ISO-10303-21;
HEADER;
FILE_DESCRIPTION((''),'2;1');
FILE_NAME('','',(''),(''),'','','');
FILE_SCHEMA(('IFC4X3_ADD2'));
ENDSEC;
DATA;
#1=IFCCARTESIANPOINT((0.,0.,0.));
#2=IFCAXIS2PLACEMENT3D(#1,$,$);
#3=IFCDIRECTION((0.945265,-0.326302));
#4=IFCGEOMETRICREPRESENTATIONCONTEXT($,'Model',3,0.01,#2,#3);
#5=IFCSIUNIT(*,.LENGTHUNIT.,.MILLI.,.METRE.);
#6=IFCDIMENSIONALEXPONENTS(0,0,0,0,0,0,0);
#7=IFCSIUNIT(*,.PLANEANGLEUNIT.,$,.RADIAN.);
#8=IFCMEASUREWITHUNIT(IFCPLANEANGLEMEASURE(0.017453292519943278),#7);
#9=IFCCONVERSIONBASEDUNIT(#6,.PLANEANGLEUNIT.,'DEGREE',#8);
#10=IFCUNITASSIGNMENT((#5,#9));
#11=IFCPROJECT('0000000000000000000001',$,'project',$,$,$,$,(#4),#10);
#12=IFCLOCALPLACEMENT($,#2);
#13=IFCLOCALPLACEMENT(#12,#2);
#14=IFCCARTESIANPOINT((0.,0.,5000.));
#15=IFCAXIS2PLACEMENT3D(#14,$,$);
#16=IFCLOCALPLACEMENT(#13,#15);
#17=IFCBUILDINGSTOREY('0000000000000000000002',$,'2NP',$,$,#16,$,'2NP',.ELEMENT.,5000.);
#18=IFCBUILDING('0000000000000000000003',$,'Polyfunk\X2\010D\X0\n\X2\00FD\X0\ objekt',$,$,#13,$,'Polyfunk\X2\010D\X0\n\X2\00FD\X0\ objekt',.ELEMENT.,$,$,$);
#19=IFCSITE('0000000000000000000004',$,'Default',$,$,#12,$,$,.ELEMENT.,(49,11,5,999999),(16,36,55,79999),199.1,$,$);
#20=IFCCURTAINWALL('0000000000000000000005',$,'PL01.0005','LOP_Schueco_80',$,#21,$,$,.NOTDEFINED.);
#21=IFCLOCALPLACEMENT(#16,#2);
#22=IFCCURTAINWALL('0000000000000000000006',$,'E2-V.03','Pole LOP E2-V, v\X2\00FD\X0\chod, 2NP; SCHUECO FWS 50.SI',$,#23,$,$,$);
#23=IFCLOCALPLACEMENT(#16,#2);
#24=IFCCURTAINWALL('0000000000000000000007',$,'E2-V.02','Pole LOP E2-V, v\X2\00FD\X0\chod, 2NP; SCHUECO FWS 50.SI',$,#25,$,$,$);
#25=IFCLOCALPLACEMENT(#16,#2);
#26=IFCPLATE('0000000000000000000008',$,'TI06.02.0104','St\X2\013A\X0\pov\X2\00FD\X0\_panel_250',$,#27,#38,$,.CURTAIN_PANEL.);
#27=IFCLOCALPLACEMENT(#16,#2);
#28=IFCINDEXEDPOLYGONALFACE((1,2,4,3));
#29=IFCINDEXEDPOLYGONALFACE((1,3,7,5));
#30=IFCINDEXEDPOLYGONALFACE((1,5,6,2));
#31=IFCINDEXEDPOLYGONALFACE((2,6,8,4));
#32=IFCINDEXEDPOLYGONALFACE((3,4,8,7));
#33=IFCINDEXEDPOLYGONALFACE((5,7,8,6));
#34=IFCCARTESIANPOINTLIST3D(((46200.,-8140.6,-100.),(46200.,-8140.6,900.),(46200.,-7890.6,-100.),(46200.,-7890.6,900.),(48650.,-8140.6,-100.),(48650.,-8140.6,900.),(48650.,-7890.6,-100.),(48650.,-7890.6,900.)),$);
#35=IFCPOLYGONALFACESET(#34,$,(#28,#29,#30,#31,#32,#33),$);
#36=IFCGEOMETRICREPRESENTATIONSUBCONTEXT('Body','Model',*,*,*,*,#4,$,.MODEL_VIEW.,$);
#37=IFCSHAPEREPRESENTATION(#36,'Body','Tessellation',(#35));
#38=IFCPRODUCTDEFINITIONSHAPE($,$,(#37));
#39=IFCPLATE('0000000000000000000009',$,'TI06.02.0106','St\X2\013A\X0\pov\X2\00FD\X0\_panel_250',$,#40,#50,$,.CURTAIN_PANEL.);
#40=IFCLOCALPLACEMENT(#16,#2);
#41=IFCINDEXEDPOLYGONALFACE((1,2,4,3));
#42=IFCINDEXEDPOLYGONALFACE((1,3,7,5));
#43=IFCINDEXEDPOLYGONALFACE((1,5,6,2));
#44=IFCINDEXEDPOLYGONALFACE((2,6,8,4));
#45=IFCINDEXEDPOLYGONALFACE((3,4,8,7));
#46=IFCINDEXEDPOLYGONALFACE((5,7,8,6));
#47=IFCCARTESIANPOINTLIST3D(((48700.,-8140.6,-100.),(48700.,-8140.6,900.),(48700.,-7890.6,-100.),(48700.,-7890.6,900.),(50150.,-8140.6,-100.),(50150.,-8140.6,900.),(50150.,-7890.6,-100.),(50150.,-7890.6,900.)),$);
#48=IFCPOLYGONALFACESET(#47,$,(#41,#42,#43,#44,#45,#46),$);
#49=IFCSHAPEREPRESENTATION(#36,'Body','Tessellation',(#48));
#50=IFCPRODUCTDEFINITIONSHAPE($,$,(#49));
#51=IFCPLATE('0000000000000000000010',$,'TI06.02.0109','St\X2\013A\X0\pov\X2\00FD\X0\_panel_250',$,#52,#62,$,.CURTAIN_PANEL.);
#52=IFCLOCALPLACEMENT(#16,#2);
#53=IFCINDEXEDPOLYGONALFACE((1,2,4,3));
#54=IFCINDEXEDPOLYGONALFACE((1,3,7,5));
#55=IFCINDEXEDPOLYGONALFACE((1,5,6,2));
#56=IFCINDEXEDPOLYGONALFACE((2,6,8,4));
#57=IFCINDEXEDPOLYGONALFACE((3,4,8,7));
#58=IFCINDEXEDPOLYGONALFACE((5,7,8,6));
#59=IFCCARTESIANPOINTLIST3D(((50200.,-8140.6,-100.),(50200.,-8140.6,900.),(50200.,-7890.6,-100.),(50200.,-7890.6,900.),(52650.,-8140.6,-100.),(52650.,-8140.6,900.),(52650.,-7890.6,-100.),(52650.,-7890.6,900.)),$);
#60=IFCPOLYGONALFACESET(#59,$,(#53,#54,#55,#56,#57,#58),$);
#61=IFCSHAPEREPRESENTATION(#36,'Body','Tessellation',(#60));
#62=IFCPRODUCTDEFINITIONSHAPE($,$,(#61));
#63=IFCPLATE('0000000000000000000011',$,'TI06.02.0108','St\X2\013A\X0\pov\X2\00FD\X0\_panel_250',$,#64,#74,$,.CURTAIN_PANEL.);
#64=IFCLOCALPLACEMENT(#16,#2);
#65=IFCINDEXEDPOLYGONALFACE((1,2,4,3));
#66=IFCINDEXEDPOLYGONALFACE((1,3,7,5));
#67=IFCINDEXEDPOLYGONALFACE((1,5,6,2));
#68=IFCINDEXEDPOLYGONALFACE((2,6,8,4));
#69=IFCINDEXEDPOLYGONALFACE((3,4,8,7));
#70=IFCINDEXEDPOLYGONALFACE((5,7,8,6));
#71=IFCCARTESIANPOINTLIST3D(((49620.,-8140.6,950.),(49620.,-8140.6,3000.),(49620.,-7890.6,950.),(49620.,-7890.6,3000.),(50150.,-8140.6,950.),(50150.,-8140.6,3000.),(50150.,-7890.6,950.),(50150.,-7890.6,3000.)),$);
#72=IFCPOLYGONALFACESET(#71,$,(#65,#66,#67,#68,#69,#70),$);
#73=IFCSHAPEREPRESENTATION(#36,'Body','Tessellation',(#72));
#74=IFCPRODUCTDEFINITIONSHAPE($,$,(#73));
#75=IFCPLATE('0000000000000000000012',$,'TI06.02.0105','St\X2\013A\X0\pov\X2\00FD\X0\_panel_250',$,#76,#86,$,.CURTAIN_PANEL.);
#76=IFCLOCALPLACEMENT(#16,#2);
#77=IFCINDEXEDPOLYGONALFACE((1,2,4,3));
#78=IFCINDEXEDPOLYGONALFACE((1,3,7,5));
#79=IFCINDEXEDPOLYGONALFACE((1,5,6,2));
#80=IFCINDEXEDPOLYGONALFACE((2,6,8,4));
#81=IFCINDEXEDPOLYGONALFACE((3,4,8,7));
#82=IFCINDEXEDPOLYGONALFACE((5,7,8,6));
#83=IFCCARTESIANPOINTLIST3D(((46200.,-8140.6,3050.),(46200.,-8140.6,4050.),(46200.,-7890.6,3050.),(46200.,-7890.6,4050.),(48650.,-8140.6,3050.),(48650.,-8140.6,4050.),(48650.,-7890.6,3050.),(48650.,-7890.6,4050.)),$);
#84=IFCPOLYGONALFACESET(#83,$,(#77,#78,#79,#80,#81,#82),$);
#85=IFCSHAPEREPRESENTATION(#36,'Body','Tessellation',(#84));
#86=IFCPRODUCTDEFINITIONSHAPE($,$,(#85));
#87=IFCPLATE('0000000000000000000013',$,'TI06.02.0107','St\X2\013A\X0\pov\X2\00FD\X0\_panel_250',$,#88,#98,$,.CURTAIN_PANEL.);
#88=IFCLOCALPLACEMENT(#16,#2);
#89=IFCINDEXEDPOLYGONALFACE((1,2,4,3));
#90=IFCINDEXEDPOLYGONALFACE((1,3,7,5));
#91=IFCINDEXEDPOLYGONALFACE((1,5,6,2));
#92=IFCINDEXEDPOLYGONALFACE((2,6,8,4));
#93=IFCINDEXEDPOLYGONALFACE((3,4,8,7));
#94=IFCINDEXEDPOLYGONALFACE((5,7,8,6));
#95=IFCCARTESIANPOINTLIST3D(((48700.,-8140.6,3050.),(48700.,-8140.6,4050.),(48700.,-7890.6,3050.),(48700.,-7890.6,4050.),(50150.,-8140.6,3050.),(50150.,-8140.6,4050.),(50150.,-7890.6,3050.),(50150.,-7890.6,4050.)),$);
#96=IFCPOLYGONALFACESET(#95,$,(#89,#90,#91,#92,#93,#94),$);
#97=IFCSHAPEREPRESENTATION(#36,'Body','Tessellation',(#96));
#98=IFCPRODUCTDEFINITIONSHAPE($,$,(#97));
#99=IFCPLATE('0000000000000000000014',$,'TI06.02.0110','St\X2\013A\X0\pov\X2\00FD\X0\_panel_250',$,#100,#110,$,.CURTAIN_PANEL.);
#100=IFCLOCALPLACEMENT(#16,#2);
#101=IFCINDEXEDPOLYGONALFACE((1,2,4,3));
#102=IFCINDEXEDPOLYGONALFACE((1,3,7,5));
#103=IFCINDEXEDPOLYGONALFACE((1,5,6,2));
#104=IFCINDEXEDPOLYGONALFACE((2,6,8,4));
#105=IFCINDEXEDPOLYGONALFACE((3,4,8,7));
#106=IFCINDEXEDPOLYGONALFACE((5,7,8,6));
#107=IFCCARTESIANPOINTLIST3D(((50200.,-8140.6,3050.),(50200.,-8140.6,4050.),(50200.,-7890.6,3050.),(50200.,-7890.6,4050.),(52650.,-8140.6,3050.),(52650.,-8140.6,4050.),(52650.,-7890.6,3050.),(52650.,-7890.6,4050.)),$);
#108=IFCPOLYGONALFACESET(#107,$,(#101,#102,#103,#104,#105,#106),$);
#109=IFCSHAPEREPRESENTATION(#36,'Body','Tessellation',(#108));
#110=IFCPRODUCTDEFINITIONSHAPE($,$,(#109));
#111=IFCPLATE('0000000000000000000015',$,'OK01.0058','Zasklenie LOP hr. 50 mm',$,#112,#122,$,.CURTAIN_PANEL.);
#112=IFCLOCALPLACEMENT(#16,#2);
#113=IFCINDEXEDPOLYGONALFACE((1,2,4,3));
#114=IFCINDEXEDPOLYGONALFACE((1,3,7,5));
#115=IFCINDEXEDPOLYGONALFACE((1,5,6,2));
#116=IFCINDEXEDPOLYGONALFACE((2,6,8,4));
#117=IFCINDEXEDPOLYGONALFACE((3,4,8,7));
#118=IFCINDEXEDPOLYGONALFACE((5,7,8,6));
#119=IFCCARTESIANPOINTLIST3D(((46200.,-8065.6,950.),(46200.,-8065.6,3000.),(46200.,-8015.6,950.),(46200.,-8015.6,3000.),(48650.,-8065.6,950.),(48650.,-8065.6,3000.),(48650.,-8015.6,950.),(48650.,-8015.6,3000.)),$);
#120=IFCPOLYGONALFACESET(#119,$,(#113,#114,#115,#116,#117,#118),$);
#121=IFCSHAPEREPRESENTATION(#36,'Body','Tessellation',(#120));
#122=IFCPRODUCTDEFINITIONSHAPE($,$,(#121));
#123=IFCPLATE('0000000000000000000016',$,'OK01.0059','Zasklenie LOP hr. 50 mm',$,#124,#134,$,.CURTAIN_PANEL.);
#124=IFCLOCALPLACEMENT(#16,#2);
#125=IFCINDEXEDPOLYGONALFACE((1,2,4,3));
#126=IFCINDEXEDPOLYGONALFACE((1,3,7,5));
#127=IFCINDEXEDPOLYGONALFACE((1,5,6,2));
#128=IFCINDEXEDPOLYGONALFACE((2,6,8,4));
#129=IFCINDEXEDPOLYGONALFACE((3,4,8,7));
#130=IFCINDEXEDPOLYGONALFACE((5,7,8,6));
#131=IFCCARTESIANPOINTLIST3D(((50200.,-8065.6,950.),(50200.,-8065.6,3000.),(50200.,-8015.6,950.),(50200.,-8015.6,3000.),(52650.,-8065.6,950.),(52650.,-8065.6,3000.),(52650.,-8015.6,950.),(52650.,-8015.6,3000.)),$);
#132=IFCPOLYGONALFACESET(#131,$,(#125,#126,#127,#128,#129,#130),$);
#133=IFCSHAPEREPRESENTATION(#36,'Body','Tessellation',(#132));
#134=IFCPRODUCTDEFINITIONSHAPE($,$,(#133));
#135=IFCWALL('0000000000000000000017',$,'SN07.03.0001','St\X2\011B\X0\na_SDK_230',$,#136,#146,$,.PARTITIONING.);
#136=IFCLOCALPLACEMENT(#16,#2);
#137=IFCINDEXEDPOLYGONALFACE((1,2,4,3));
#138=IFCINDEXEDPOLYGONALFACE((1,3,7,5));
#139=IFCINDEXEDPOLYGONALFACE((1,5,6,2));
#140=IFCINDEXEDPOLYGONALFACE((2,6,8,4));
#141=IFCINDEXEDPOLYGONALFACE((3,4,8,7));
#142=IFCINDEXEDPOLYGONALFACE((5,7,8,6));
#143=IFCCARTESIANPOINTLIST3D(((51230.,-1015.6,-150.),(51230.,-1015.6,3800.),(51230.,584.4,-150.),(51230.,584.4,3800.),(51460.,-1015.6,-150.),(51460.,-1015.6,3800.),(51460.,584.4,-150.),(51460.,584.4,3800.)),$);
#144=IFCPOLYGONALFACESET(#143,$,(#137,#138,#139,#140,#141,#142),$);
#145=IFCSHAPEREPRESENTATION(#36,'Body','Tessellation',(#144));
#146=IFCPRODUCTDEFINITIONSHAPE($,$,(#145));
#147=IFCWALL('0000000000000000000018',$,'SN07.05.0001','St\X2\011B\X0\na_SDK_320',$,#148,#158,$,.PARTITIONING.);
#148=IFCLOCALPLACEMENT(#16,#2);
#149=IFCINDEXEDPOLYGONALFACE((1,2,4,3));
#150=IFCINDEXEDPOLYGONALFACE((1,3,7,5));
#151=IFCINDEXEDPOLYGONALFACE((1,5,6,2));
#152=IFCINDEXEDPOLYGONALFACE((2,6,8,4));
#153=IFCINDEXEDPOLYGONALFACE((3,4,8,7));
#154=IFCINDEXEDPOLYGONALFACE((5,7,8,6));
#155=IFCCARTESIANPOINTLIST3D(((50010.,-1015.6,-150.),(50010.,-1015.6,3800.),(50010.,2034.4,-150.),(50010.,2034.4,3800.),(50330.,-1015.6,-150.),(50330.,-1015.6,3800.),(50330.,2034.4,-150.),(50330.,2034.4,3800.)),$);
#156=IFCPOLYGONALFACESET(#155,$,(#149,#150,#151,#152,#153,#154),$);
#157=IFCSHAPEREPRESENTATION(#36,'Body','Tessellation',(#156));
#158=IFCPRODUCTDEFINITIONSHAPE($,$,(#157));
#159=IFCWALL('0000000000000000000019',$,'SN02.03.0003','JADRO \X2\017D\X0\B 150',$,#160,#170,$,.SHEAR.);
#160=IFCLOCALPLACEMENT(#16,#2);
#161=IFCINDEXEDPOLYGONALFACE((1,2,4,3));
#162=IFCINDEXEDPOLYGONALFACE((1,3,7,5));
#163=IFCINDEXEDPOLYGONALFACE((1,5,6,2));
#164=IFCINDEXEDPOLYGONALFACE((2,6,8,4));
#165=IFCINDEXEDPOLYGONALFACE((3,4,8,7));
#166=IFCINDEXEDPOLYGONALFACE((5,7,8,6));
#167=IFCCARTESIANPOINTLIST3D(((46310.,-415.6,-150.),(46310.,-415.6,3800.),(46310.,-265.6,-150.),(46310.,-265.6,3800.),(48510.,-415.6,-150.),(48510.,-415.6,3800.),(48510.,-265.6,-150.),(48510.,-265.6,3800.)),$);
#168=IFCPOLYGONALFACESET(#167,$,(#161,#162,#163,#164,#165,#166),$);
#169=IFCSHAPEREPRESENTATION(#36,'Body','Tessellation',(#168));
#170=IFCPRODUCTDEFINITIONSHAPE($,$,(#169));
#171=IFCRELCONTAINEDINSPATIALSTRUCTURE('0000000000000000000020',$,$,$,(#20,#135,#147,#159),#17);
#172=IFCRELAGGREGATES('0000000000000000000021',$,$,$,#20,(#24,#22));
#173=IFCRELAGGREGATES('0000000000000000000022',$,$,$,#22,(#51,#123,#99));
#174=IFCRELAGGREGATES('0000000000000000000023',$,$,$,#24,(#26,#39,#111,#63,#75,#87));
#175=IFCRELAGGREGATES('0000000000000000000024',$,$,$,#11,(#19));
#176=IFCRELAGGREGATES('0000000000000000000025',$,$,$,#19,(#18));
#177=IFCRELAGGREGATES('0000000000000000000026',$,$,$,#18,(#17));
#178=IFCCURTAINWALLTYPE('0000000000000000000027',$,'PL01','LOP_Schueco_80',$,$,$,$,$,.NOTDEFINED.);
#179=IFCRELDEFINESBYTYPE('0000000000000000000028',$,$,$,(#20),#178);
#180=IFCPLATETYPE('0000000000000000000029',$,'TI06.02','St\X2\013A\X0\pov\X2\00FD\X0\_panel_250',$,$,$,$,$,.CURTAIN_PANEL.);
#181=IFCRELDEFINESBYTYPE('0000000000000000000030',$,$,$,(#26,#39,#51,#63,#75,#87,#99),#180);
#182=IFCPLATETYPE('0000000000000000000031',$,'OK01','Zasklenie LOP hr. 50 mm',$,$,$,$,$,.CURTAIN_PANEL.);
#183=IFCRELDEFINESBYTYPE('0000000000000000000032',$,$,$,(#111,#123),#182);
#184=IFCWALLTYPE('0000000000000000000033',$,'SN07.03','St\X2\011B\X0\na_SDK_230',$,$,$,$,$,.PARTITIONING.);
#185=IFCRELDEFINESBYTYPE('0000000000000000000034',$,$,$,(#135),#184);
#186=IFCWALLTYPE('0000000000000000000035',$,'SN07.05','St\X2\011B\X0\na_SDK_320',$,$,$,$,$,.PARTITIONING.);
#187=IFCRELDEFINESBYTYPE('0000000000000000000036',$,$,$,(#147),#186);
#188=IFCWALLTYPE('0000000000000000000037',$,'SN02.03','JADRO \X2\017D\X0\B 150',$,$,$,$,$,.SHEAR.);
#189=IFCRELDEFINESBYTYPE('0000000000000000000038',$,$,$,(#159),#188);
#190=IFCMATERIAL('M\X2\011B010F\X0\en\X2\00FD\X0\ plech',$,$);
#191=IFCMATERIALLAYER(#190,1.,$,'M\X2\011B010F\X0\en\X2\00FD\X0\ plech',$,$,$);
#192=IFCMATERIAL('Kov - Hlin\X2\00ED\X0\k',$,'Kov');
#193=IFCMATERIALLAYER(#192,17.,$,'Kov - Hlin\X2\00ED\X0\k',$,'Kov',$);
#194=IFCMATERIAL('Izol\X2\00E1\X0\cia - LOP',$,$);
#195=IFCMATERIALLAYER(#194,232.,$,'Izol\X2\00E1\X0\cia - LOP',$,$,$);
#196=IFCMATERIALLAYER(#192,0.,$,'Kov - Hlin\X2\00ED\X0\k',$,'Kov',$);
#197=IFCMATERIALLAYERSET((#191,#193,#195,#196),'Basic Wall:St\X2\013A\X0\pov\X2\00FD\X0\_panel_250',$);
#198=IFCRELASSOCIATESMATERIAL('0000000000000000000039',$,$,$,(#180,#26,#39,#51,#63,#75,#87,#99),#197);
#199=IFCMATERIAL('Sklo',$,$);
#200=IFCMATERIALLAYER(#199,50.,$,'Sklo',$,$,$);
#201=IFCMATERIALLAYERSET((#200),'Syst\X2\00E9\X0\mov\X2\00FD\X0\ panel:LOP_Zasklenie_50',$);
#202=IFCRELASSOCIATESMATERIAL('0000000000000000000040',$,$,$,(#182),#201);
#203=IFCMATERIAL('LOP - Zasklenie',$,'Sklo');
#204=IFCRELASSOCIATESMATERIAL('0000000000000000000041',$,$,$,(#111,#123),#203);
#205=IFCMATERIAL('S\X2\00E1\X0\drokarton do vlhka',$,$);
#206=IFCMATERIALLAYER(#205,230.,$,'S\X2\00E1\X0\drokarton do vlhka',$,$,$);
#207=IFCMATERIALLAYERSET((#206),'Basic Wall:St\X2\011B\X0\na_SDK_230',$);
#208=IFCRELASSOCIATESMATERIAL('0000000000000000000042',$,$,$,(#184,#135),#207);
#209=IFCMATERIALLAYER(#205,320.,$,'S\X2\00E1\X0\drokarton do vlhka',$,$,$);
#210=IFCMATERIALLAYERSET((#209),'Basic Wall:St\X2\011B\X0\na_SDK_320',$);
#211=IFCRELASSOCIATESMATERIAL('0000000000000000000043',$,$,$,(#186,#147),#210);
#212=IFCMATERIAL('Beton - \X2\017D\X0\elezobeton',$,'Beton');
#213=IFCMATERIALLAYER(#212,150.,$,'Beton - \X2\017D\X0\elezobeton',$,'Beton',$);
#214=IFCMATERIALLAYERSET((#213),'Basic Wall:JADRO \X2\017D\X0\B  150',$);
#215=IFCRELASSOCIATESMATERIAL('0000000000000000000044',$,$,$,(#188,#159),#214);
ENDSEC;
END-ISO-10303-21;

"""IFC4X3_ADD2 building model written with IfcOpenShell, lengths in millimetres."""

from ifc_helpers import new_model, entity, si_unit, converted_unit, direction, frame, frame_2d, origin, origin_2d_with_axis, place, context, subcontext, project, spatial, polyline, rectangle, extrude, clip, bounded_halfspace, source, transform, mapped, material, layer, layer_set, layer_usage, type_object, type_shapes, element, aggregate, save


model = new_model("IFC4X3_ADD2")

# Units and contexts
model_context = context("Model", 3, precision=0.01, world=origin(), true_north=direction((0.945265, -0.326302)))
body_context = subcontext(model_context, "Body", "Model", "MODEL_VIEW")
ifc_project = project(units=[si_unit("LENGTHUNIT", "METRE", prefix="MILLI"), converted_unit("PLANEANGLEUNIT", "DEGREE", entity("IfcPlaneAngleMeasure", 0.017453292519943278), si_unit("PLANEANGLEUNIT", "RADIAN"), dimensions=[0, 0, 0, 0, 0, 0, 0])], contexts=[model_context])

# Site, building, storey
site_placement = place(None, origin())
site = spatial("IfcSite", under=ifc_project, at=site_placement, Name="Default", CompositionType="ELEMENT", RefLatitude=(49, 11, 5, 999999), RefLongitude=(16, 36, 55, 79999), RefElevation=199.1)
building_placement = place(site_placement, origin())
building = spatial("IfcBuilding", under=site, at=building_placement, Name="Polyfunkčný objekt", LongName="Polyfunkčný objekt", CompositionType="ELEMENT")
storey_placement = place(building_placement, frame((0.0, 0.0, 5000.0)))
storey = spatial("IfcBuildingStorey", under=building, at=storey_placement, Name="2NP", LongName="2NP", CompositionType="ELEMENT", Elevation=5000.0)

# Curtain walls, plates
curtain_wall_type = type_object("IfcCurtainWallType", Name="PL01", Description="LOP_Schueco_80", PredefinedType="NOTDEFINED")
curtain_wall_1_placement = place(storey_placement, frame((0.0, 0.0, -5000.0)))
curtain_wall_1 = element("IfcCurtainWall", 1, at=curtain_wall_1_placement, inside=storey, type_object=curtain_wall_type, Name="PL01.0005", Description="LOP_Schueco_80", PredefinedType="NOTDEFINED")
curtain_wall_2 = element("IfcCurtainWall", 2, Name="E2-V.03", Description="Pole LOP E2-V, východ, 2NP; SCHUECO FWS 50.SI")
curtain_wall_3 = element("IfcCurtainWall", 3, Name="E2-V.02", Description="Pole LOP E2-V, východ, 2NP; SCHUECO FWS 50.SI")
aggregate(curtain_wall_1, [curtain_wall_3, curtain_wall_2])
ifc_material_1 = material(Name="Měďený plech")
ifc_layer_1 = layer(ifc_material_1, 1.0, Name="Měďený plech")
ifc_material_2 = material(Name="Kov - Hliník", Category="Kov")
ifc_layer_2 = layer(ifc_material_2, 17.0, Name="Kov - Hliník", Category="Kov")
ifc_material_3 = material(Name="Izolácia - LOP")
ifc_layer_3 = layer(ifc_material_3, 232.0, Name="Izolácia - LOP")
ifc_layer_4 = layer(ifc_material_2, 0.0, Name="Kov - Hliník", Category="Kov")
ifc_layer_set_1 = layer_set([ifc_layer_1, ifc_layer_2, ifc_layer_3, ifc_layer_4], Name="Basic Wall:Stĺpový_panel_250")
ifc_layer_usage_1 = layer_usage(ifc_layer_set_1, "AXIS2", "POSITIVE", -125.0)
plate_type_1 = type_object("IfcPlateType", Name="TI06.02", Description="Stĺpový_panel_250", PredefinedType="CURTAIN_PANEL", material=ifc_layer_set_1)
plate_1_placement = place(storey_placement, frame((46200.0, -8015.6, -100.0)))
plate_1 = element("IfcPlate", 4, at=plate_1_placement, type_object=plate_type_1, material=ifc_layer_usage_1, Name="TI06.02.0104", Description="Stĺpový_panel_250", PredefinedType="CURTAIN_PANEL", context=body_context, shape_type="SweptSolid", body=[
    extrude(rectangle(XDim=250.0, YDim=2450.0, at=frame_2d((0.0, 0.0), x_axis=(1.0, 0.0))), frame((1225.0, 0.0, 0.0), z_axis=(0.0, 0.0, 1.0), x_axis=(0.0, 1.0, 0.0)), (0.0, 0.0, 1.0), 1000.0),
])
ifc_layer_usage_2 = layer_usage(ifc_layer_set_1, "AXIS2", "POSITIVE", -125.0)
plate_2_placement = place(storey_placement, frame((48700.0, -8015.6, -100.0)))
plate_2 = element("IfcPlate", 5, at=plate_2_placement, type_object=plate_type_1, material=ifc_layer_usage_2, Name="TI06.02.0106", Description="Stĺpový_panel_250", PredefinedType="CURTAIN_PANEL", context=body_context, shape_type="SweptSolid", body=[
    extrude(rectangle(XDim=250.0, YDim=1450.0, at=frame_2d((0.0, 0.0), x_axis=(1.0, 0.0))), frame((725.0, 0.0, 0.0), z_axis=(0.0, 0.0, 1.0), x_axis=(0.0, 1.0, 0.0)), (0.0, 0.0, 1.0), 1000.0),
])
ifc_layer_usage_3 = layer_usage(ifc_layer_set_1, "AXIS2", "POSITIVE", -125.0)
plate_3_placement = place(storey_placement, frame((50200.0, -8015.6, -100.0)))
plate_3 = element("IfcPlate", 6, at=plate_3_placement, type_object=plate_type_1, material=ifc_layer_usage_3, Name="TI06.02.0109", Description="Stĺpový_panel_250", PredefinedType="CURTAIN_PANEL", context=body_context, shape_type="SweptSolid", body=[
    extrude(rectangle(XDim=250.0, YDim=2450.0, at=origin_2d_with_axis()), frame((1225.0, 0.0, 0.0), z_axis=(0.0, 0.0, 1.0), x_axis=(0.0, 1.0, 0.0)), (0.0, 0.0, 1.0), 1000.0),
])
ifc_layer_usage_4 = layer_usage(ifc_layer_set_1, "AXIS2", "POSITIVE", -125.0)
plate_4_placement = place(storey_placement, frame((49620.0, -8015.6, 950.0)))
plate_4 = element("IfcPlate", 7, at=plate_4_placement, type_object=plate_type_1, material=ifc_layer_usage_4, Name="TI06.02.0108", Description="Stĺpový_panel_250", PredefinedType="CURTAIN_PANEL", context=body_context, shape_type="SweptSolid", body=[
    extrude(rectangle(XDim=250.0, YDim=530.0, at=frame_2d((0.0, 0.0), x_axis=(1.0, 0.0))), frame((265.0, 0.0, 0.0), z_axis=(0.0, 0.0, 1.0), x_axis=(0.0, 1.0, 0.0)), (0.0, 0.0, 1.0), 2050.0),
])
ifc_layer_usage_5 = layer_usage(ifc_layer_set_1, "AXIS2", "POSITIVE", -125.0)
plate_5_placement = place(storey_placement, frame((46200.0, -8015.6, 3050.0)))
plate_5 = element("IfcPlate", 8, at=plate_5_placement, type_object=plate_type_1, material=ifc_layer_usage_5, Name="TI06.02.0105", Description="Stĺpový_panel_250", PredefinedType="CURTAIN_PANEL", context=body_context, shape_type="SweptSolid", body=[
    extrude(rectangle(XDim=250.0, YDim=2450.0, at=frame_2d((0.0, 0.0), x_axis=(1.0, 0.0))), frame((1225.0, 0.0, 0.0), z_axis=(0.0, 0.0, 1.0), x_axis=(0.0, 1.0, 0.0)), (0.0, 0.0, 1.0), 1000.0),
])
ifc_layer_usage_6 = layer_usage(ifc_layer_set_1, "AXIS2", "POSITIVE", -125.0)
plate_6_placement = place(storey_placement, frame((48700.0, -8015.6, 3050.0)))
plate_6 = element("IfcPlate", 9, at=plate_6_placement, type_object=plate_type_1, material=ifc_layer_usage_6, Name="TI06.02.0107", Description="Stĺpový_panel_250", PredefinedType="CURTAIN_PANEL", context=body_context, shape_type="SweptSolid", body=[
    extrude(rectangle(XDim=250.0, YDim=1450.0, at=frame_2d((0.0, 0.0), x_axis=(1.0, 0.0))), frame((725.0, 0.0, 0.0), z_axis=(0.0, 0.0, 1.0), x_axis=(0.0, 1.0, 0.0)), (0.0, 0.0, 1.0), 1000.0),
])
ifc_layer_usage_7 = layer_usage(ifc_layer_set_1, "AXIS2", "POSITIVE", -125.0)
plate_7_placement = place(storey_placement, frame((50200.0, -8015.6, 3050.0)))
plate_7 = element("IfcPlate", 10, at=plate_7_placement, type_object=plate_type_1, material=ifc_layer_usage_7, Name="TI06.02.0110", Description="Stĺpový_panel_250", PredefinedType="CURTAIN_PANEL", context=body_context, shape_type="SweptSolid", body=[
    extrude(rectangle(XDim=250.0, YDim=2450.0, at=origin_2d_with_axis()), frame((1225.0, 0.0, 0.0), z_axis=(0.0, 0.0, 1.0), x_axis=(0.0, 1.0, 0.0)), (0.0, 0.0, 1.0), 1000.0),
])
ifc_material_4 = material(Name="LOP - Zasklenie", Category="Sklo")
ifc_material_5 = material(Name="Sklo")
ifc_layer_5 = layer(ifc_material_5, 50.0, Name="Sklo")
ifc_layer_set_2 = layer_set([ifc_layer_5], Name="Systémový panel:LOP_Zasklenie_50")
plate_type_2 = type_object("IfcPlateType", Name="OK01", Description="Zasklenie LOP hr. 50 mm", PredefinedType="CURTAIN_PANEL", material=ifc_layer_set_2)
shared_shape_1 = source(origin(), body_context, "Body", "SweptSolid", [
    extrude(rectangle(XDim=50.0, YDim=2450.0, at=origin_2d_with_axis()), frame((0.0, -25.0, 0.0), z_axis=(0.0, 0.0, 1.0), x_axis=(0.0, 1.0, 0.0)), (0.0, 0.0, 1.0), 2050.0),
])
type_shapes(plate_type_2, [shared_shape_1])
plate_8_placement = place(curtain_wall_1_placement, frame((47425.0, -8015.6, 5950.0)))
plate_8 = element("IfcPlate", 11, at=plate_8_placement, type_object=plate_type_2, material=ifc_material_4, Name="OK01.0058", Description="Zasklenie LOP hr. 50 mm", PredefinedType="CURTAIN_PANEL", context=body_context, shape_type="MappedRepresentation", body=[
    mapped(shared_shape_1, transform((0.0, 0.0, 0.0), scale=1.0)),
])
plate_9_placement = place(curtain_wall_1_placement, frame((51425.0, -8015.6, 5950.0)))
plate_9 = element("IfcPlate", 12, at=plate_9_placement, type_object=plate_type_2, material=ifc_material_4, Name="OK01.0059", Description="Zasklenie LOP hr. 50 mm", PredefinedType="CURTAIN_PANEL", context=body_context, shape_type="MappedRepresentation", body=[
    mapped(shared_shape_1, transform((0.0, 0.0, 0.0), scale=1.0)),
])
aggregate(curtain_wall_2, [plate_3, plate_9, plate_7])

# Walls
ifc_material_6 = material(Name="Sádrokarton do vlhka")
ifc_layer_6 = layer(ifc_material_6, 230.0, Name="Sádrokarton do vlhka")
ifc_layer_set_3 = layer_set([ifc_layer_6], Name="Basic Wall:Stěna_SDK_230")
wall_type_1 = type_object("IfcWallType", Name="SN07.03", Description="Stěna_SDK_230", PredefinedType="PARTITIONING", material=ifc_layer_set_3)
wall_1_placement = place(storey_placement, frame((51345.0, 584.4, -150.0), z_axis=(0.0, 0.0, 1.0), x_axis=(0.0, -1.0, 0.0)))
element("IfcWall", 13, at=wall_1_placement, inside=storey, type_object=wall_type_1, material=ifc_layer_set_3, Name="SN07.03.0001", Description="Stěna_SDK_230", PredefinedType="PARTITIONING", context=body_context, shape_type="Clipping", body=[
    clip(clip(extrude(rectangle(XDim=1600.0, YDim=230.0, at=frame_2d((800.0, 0.0), x_axis=(-1.0, 0.0))), origin(), (0.0, 0.0, 1.0), 3950.0), bounded_halfspace(frame((1600.0, -115.0, 0.0), z_axis=(0.0, 0.0, 1.0), x_axis=(0.0, -1.0, 0.0)), True, frame((1600.0, -115.0, 0.0)), polyline([(0.0, 0.0), (0.0, 230.0), (-1600.0, 230.0), (-1600.0, 0.0), (0.0, 0.0)]))), bounded_halfspace(frame((0.0, -115.0, 3950.0), z_axis=(0.0, 0.0, -1.0), x_axis=(0.0, 1.0, 0.0)), True, frame((0.0, -115.0, 3950.0)), polyline([(0.0, 0.0), (1600.0, 0.0), (1600.0, 230.0), (0.0, 230.0), (0.0, 0.0)]))),
])
ifc_layer_7 = layer(ifc_material_6, 320.0, Name="Sádrokarton do vlhka")
ifc_layer_set_4 = layer_set([ifc_layer_7], Name="Basic Wall:Stěna_SDK_320")
wall_type_2 = type_object("IfcWallType", Name="SN07.05", Description="Stěna_SDK_320", PredefinedType="PARTITIONING", material=ifc_layer_set_4)
wall_2_placement = place(storey_placement, frame((50170.0, 2034.4, -150.0), z_axis=(0.0, 0.0, 1.0), x_axis=(0.0, -1.0, 0.0)))
element("IfcWall", 14, at=wall_2_placement, inside=storey, type_object=wall_type_2, material=ifc_layer_set_4, Name="SN07.05.0001", Description="Stěna_SDK_320", PredefinedType="PARTITIONING", context=body_context, shape_type="Clipping", body=[
    clip(clip(extrude(rectangle(XDim=3050.0, YDim=320.0, at=frame_2d((1525.0, 0.0), x_axis=(-1.0, 0.0))), origin(), (0.0, 0.0, 1.0), 3950.0), bounded_halfspace(frame((3050.0, -160.0, 0.0), z_axis=(0.0, 0.0, 1.0), x_axis=(0.0, -1.0, 0.0)), True, frame((3050.0, -160.0, 0.0)), polyline([(0.0, 0.0), (0.0, 320.0), (-1600.0, 320.0), (-1750.0, 320.0), (-2900.0, 320.0), (-3050.0, 320.0), (-3050.0, 0.0), (0.0, 0.0)]))), bounded_halfspace(frame((0.0, -160.0, 3950.0), z_axis=(0.0, 0.0, -1.0), x_axis=(0.0, 1.0, 0.0)), True, frame((0.0, -160.0, 3950.0)), polyline([(0.0, 0.0), (3050.0, 0.0), (3050.0, 320.0), (1450.0, 320.0), (1300.0, 320.0), (150.0, 320.0), (0.0, 320.0), (0.0, 0.0)]))),
])
ifc_material_7 = material(Name="Beton - Železobeton", Category="Beton")
ifc_layer_8 = layer(ifc_material_7, 150.0, Name="Beton - Železobeton", Category="Beton")
ifc_layer_set_5 = layer_set([ifc_layer_8], Name="Basic Wall:JADRO ŽB  150")
wall_type_3 = type_object("IfcWallType", Name="SN02.03", Description="JADRO ŽB 150", PredefinedType="SHEAR", material=ifc_layer_set_5)
placement = place(building_placement, origin())
wall_3_placement = place(placement, frame((46310.0, -340.6, 4850.0)))
element("IfcWall", 15, at=wall_3_placement, inside=storey, type_object=wall_type_3, material=ifc_layer_set_5, Name="SN02.03.0003", Description="JADRO ŽB 150", PredefinedType="SHEAR", context=body_context, shape_type="Clipping", body=[
    clip(clip(extrude(rectangle(XDim=2200.0, YDim=150.0, at=frame_2d((1100.0, 0.0), x_axis=(-1.0, 0.0))), origin(), (0.0, 0.0, 1.0), 3950.0), bounded_halfspace(frame((2200.0, -75.0, 0.0), z_axis=(0.0, 0.0, 1.0), x_axis=(-1.0, 0.0, 0.0)), True, frame((2200.0, -75.0, 0.0)), polyline([(0.0, 0.0), (0.0, 150.0), (-2200.0, 150.0), (-2200.0, 0.0), (0.0, 0.0)]))), bounded_halfspace(frame((0.0, -75.0, 3950.0), z_axis=(0.0, 0.0, -1.0), x_axis=(1.0, 0.0, 0.0)), True, frame((0.0, -75.0, 3950.0)), polyline([(0.0, 0.0), (2050.0, 0.0), (2200.0, 0.0), (2200.0, 150.0), (0.0, 150.0), (0.0, 0.0)]))),
])

aggregate(curtain_wall_3, [plate_1, plate_2, plate_8, plate_4, plate_5, plate_6])

save(model, "model.ifc")
